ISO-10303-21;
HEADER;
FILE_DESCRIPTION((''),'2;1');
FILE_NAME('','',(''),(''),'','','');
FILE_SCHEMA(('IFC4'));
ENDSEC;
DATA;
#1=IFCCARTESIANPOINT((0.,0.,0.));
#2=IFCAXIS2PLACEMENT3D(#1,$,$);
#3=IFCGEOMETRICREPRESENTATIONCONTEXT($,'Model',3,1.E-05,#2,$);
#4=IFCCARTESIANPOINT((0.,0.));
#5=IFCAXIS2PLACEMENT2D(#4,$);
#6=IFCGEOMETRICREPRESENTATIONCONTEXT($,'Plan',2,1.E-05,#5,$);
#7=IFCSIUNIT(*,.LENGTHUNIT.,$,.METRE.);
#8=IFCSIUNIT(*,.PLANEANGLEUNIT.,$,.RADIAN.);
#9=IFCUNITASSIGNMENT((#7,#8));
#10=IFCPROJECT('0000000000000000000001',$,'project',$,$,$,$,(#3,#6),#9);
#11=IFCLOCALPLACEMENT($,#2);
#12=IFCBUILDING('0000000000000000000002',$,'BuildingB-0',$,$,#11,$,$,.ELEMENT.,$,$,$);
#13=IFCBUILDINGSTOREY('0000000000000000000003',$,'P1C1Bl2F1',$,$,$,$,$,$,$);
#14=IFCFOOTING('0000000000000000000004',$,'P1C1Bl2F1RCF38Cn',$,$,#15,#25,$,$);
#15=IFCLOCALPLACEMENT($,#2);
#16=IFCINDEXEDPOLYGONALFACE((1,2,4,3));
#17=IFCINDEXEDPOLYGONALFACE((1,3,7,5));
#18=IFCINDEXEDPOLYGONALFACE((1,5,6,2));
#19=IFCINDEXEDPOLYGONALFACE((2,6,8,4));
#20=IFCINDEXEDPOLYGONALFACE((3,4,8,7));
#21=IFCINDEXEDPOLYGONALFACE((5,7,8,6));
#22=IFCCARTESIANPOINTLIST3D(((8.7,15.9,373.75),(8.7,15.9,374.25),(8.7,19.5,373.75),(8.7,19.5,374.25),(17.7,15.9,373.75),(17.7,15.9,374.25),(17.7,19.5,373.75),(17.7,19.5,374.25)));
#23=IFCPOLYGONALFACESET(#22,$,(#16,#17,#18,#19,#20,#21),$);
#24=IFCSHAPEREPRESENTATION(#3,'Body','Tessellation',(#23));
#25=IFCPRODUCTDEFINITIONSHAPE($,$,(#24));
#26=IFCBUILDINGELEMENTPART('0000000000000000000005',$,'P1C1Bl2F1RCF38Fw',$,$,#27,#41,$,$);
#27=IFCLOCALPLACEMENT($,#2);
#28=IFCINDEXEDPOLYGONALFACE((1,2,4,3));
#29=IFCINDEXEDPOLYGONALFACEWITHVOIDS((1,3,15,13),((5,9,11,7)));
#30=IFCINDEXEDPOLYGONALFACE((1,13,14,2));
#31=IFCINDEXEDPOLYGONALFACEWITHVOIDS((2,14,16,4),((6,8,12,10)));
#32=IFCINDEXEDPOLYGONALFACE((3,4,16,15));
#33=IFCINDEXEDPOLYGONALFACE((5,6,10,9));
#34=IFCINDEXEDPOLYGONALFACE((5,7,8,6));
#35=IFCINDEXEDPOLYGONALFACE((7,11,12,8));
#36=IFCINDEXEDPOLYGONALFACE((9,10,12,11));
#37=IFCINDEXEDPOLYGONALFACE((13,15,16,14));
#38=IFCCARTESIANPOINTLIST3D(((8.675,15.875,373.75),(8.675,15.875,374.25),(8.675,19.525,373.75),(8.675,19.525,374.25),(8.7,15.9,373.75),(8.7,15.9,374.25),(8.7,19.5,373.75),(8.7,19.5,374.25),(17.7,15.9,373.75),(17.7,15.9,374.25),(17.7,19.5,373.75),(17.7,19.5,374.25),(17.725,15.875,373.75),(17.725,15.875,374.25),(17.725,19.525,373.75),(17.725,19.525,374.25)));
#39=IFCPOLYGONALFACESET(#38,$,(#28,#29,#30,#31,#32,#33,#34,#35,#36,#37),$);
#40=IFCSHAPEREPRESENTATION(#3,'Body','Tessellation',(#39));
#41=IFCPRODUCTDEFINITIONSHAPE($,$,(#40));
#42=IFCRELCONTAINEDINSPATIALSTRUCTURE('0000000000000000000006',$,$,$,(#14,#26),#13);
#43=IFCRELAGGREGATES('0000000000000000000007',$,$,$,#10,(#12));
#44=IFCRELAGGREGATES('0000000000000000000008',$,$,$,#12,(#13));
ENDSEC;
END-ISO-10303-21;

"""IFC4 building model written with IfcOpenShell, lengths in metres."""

from ifc_helpers import new_model, si_unit, origin, origin_2d, place, context, project, spatial, polyline, outline, extrude, element, save


model = new_model("IFC4")

# Units and contexts
model_context = context("Model", 3, precision=1e-05, world=origin())
plan_context = context("Plan", 2, precision=1e-05, world=origin_2d())
ifc_project = project(units=[si_unit("LENGTHUNIT", "METRE"), si_unit("PLANEANGLEUNIT", "RADIAN")], contexts=[model_context, plan_context])

# Building, storey
building_placement = place(None, origin())
building = spatial("IfcBuilding", under=ifc_project, at=building_placement, Name="BuildingB-0", CompositionType="ELEMENT")
storey = spatial("IfcBuildingStorey", under=building, Name="P1C1Bl2F1")

# Footing
element("IfcFooting", 1, inside=storey, Name="P1C1Bl2F1RCF38Cn", context=model_context, shape_type="SweptSolid", body=[
    extrude(outline(polyline([(17.7, 19.5, 373.75), (8.7, 19.5, 373.75), (8.7, 15.9, 373.75), (17.7, 15.9, 373.75), (17.7, 19.5, 373.75)])), None, (0.0, 0.0, 1.0), 0.5),
])

# Building element part, opening
building_element_part = element("IfcBuildingElementPart", 2, inside=storey, Name="P1C1Bl2F1RCF38Fw", context=model_context, shape_type="SweptSolid", body=[
    extrude(outline(polyline([(17.725, 19.525, 373.75), (8.675, 19.525, 373.75), (8.675, 15.875, 373.75), (17.725, 15.875, 373.75), (17.725, 19.525, 373.75)])), None, (0.0, 0.0, 1.0), 0.5),
])
element("IfcOpeningElement", 3, inside=storey, cuts=building_element_part, context=model_context, shape_type="SweptSolid", body=[
    extrude(outline(polyline([(17.7, 19.5, 373.75), (8.7, 19.5, 373.75), (8.7, 15.9, 373.75), (17.7, 15.9, 373.75), (17.7, 19.5, 373.75)])), None, (0.0, 0.0, 1.0), 0.5),
])

save(model, "model.ifc")
